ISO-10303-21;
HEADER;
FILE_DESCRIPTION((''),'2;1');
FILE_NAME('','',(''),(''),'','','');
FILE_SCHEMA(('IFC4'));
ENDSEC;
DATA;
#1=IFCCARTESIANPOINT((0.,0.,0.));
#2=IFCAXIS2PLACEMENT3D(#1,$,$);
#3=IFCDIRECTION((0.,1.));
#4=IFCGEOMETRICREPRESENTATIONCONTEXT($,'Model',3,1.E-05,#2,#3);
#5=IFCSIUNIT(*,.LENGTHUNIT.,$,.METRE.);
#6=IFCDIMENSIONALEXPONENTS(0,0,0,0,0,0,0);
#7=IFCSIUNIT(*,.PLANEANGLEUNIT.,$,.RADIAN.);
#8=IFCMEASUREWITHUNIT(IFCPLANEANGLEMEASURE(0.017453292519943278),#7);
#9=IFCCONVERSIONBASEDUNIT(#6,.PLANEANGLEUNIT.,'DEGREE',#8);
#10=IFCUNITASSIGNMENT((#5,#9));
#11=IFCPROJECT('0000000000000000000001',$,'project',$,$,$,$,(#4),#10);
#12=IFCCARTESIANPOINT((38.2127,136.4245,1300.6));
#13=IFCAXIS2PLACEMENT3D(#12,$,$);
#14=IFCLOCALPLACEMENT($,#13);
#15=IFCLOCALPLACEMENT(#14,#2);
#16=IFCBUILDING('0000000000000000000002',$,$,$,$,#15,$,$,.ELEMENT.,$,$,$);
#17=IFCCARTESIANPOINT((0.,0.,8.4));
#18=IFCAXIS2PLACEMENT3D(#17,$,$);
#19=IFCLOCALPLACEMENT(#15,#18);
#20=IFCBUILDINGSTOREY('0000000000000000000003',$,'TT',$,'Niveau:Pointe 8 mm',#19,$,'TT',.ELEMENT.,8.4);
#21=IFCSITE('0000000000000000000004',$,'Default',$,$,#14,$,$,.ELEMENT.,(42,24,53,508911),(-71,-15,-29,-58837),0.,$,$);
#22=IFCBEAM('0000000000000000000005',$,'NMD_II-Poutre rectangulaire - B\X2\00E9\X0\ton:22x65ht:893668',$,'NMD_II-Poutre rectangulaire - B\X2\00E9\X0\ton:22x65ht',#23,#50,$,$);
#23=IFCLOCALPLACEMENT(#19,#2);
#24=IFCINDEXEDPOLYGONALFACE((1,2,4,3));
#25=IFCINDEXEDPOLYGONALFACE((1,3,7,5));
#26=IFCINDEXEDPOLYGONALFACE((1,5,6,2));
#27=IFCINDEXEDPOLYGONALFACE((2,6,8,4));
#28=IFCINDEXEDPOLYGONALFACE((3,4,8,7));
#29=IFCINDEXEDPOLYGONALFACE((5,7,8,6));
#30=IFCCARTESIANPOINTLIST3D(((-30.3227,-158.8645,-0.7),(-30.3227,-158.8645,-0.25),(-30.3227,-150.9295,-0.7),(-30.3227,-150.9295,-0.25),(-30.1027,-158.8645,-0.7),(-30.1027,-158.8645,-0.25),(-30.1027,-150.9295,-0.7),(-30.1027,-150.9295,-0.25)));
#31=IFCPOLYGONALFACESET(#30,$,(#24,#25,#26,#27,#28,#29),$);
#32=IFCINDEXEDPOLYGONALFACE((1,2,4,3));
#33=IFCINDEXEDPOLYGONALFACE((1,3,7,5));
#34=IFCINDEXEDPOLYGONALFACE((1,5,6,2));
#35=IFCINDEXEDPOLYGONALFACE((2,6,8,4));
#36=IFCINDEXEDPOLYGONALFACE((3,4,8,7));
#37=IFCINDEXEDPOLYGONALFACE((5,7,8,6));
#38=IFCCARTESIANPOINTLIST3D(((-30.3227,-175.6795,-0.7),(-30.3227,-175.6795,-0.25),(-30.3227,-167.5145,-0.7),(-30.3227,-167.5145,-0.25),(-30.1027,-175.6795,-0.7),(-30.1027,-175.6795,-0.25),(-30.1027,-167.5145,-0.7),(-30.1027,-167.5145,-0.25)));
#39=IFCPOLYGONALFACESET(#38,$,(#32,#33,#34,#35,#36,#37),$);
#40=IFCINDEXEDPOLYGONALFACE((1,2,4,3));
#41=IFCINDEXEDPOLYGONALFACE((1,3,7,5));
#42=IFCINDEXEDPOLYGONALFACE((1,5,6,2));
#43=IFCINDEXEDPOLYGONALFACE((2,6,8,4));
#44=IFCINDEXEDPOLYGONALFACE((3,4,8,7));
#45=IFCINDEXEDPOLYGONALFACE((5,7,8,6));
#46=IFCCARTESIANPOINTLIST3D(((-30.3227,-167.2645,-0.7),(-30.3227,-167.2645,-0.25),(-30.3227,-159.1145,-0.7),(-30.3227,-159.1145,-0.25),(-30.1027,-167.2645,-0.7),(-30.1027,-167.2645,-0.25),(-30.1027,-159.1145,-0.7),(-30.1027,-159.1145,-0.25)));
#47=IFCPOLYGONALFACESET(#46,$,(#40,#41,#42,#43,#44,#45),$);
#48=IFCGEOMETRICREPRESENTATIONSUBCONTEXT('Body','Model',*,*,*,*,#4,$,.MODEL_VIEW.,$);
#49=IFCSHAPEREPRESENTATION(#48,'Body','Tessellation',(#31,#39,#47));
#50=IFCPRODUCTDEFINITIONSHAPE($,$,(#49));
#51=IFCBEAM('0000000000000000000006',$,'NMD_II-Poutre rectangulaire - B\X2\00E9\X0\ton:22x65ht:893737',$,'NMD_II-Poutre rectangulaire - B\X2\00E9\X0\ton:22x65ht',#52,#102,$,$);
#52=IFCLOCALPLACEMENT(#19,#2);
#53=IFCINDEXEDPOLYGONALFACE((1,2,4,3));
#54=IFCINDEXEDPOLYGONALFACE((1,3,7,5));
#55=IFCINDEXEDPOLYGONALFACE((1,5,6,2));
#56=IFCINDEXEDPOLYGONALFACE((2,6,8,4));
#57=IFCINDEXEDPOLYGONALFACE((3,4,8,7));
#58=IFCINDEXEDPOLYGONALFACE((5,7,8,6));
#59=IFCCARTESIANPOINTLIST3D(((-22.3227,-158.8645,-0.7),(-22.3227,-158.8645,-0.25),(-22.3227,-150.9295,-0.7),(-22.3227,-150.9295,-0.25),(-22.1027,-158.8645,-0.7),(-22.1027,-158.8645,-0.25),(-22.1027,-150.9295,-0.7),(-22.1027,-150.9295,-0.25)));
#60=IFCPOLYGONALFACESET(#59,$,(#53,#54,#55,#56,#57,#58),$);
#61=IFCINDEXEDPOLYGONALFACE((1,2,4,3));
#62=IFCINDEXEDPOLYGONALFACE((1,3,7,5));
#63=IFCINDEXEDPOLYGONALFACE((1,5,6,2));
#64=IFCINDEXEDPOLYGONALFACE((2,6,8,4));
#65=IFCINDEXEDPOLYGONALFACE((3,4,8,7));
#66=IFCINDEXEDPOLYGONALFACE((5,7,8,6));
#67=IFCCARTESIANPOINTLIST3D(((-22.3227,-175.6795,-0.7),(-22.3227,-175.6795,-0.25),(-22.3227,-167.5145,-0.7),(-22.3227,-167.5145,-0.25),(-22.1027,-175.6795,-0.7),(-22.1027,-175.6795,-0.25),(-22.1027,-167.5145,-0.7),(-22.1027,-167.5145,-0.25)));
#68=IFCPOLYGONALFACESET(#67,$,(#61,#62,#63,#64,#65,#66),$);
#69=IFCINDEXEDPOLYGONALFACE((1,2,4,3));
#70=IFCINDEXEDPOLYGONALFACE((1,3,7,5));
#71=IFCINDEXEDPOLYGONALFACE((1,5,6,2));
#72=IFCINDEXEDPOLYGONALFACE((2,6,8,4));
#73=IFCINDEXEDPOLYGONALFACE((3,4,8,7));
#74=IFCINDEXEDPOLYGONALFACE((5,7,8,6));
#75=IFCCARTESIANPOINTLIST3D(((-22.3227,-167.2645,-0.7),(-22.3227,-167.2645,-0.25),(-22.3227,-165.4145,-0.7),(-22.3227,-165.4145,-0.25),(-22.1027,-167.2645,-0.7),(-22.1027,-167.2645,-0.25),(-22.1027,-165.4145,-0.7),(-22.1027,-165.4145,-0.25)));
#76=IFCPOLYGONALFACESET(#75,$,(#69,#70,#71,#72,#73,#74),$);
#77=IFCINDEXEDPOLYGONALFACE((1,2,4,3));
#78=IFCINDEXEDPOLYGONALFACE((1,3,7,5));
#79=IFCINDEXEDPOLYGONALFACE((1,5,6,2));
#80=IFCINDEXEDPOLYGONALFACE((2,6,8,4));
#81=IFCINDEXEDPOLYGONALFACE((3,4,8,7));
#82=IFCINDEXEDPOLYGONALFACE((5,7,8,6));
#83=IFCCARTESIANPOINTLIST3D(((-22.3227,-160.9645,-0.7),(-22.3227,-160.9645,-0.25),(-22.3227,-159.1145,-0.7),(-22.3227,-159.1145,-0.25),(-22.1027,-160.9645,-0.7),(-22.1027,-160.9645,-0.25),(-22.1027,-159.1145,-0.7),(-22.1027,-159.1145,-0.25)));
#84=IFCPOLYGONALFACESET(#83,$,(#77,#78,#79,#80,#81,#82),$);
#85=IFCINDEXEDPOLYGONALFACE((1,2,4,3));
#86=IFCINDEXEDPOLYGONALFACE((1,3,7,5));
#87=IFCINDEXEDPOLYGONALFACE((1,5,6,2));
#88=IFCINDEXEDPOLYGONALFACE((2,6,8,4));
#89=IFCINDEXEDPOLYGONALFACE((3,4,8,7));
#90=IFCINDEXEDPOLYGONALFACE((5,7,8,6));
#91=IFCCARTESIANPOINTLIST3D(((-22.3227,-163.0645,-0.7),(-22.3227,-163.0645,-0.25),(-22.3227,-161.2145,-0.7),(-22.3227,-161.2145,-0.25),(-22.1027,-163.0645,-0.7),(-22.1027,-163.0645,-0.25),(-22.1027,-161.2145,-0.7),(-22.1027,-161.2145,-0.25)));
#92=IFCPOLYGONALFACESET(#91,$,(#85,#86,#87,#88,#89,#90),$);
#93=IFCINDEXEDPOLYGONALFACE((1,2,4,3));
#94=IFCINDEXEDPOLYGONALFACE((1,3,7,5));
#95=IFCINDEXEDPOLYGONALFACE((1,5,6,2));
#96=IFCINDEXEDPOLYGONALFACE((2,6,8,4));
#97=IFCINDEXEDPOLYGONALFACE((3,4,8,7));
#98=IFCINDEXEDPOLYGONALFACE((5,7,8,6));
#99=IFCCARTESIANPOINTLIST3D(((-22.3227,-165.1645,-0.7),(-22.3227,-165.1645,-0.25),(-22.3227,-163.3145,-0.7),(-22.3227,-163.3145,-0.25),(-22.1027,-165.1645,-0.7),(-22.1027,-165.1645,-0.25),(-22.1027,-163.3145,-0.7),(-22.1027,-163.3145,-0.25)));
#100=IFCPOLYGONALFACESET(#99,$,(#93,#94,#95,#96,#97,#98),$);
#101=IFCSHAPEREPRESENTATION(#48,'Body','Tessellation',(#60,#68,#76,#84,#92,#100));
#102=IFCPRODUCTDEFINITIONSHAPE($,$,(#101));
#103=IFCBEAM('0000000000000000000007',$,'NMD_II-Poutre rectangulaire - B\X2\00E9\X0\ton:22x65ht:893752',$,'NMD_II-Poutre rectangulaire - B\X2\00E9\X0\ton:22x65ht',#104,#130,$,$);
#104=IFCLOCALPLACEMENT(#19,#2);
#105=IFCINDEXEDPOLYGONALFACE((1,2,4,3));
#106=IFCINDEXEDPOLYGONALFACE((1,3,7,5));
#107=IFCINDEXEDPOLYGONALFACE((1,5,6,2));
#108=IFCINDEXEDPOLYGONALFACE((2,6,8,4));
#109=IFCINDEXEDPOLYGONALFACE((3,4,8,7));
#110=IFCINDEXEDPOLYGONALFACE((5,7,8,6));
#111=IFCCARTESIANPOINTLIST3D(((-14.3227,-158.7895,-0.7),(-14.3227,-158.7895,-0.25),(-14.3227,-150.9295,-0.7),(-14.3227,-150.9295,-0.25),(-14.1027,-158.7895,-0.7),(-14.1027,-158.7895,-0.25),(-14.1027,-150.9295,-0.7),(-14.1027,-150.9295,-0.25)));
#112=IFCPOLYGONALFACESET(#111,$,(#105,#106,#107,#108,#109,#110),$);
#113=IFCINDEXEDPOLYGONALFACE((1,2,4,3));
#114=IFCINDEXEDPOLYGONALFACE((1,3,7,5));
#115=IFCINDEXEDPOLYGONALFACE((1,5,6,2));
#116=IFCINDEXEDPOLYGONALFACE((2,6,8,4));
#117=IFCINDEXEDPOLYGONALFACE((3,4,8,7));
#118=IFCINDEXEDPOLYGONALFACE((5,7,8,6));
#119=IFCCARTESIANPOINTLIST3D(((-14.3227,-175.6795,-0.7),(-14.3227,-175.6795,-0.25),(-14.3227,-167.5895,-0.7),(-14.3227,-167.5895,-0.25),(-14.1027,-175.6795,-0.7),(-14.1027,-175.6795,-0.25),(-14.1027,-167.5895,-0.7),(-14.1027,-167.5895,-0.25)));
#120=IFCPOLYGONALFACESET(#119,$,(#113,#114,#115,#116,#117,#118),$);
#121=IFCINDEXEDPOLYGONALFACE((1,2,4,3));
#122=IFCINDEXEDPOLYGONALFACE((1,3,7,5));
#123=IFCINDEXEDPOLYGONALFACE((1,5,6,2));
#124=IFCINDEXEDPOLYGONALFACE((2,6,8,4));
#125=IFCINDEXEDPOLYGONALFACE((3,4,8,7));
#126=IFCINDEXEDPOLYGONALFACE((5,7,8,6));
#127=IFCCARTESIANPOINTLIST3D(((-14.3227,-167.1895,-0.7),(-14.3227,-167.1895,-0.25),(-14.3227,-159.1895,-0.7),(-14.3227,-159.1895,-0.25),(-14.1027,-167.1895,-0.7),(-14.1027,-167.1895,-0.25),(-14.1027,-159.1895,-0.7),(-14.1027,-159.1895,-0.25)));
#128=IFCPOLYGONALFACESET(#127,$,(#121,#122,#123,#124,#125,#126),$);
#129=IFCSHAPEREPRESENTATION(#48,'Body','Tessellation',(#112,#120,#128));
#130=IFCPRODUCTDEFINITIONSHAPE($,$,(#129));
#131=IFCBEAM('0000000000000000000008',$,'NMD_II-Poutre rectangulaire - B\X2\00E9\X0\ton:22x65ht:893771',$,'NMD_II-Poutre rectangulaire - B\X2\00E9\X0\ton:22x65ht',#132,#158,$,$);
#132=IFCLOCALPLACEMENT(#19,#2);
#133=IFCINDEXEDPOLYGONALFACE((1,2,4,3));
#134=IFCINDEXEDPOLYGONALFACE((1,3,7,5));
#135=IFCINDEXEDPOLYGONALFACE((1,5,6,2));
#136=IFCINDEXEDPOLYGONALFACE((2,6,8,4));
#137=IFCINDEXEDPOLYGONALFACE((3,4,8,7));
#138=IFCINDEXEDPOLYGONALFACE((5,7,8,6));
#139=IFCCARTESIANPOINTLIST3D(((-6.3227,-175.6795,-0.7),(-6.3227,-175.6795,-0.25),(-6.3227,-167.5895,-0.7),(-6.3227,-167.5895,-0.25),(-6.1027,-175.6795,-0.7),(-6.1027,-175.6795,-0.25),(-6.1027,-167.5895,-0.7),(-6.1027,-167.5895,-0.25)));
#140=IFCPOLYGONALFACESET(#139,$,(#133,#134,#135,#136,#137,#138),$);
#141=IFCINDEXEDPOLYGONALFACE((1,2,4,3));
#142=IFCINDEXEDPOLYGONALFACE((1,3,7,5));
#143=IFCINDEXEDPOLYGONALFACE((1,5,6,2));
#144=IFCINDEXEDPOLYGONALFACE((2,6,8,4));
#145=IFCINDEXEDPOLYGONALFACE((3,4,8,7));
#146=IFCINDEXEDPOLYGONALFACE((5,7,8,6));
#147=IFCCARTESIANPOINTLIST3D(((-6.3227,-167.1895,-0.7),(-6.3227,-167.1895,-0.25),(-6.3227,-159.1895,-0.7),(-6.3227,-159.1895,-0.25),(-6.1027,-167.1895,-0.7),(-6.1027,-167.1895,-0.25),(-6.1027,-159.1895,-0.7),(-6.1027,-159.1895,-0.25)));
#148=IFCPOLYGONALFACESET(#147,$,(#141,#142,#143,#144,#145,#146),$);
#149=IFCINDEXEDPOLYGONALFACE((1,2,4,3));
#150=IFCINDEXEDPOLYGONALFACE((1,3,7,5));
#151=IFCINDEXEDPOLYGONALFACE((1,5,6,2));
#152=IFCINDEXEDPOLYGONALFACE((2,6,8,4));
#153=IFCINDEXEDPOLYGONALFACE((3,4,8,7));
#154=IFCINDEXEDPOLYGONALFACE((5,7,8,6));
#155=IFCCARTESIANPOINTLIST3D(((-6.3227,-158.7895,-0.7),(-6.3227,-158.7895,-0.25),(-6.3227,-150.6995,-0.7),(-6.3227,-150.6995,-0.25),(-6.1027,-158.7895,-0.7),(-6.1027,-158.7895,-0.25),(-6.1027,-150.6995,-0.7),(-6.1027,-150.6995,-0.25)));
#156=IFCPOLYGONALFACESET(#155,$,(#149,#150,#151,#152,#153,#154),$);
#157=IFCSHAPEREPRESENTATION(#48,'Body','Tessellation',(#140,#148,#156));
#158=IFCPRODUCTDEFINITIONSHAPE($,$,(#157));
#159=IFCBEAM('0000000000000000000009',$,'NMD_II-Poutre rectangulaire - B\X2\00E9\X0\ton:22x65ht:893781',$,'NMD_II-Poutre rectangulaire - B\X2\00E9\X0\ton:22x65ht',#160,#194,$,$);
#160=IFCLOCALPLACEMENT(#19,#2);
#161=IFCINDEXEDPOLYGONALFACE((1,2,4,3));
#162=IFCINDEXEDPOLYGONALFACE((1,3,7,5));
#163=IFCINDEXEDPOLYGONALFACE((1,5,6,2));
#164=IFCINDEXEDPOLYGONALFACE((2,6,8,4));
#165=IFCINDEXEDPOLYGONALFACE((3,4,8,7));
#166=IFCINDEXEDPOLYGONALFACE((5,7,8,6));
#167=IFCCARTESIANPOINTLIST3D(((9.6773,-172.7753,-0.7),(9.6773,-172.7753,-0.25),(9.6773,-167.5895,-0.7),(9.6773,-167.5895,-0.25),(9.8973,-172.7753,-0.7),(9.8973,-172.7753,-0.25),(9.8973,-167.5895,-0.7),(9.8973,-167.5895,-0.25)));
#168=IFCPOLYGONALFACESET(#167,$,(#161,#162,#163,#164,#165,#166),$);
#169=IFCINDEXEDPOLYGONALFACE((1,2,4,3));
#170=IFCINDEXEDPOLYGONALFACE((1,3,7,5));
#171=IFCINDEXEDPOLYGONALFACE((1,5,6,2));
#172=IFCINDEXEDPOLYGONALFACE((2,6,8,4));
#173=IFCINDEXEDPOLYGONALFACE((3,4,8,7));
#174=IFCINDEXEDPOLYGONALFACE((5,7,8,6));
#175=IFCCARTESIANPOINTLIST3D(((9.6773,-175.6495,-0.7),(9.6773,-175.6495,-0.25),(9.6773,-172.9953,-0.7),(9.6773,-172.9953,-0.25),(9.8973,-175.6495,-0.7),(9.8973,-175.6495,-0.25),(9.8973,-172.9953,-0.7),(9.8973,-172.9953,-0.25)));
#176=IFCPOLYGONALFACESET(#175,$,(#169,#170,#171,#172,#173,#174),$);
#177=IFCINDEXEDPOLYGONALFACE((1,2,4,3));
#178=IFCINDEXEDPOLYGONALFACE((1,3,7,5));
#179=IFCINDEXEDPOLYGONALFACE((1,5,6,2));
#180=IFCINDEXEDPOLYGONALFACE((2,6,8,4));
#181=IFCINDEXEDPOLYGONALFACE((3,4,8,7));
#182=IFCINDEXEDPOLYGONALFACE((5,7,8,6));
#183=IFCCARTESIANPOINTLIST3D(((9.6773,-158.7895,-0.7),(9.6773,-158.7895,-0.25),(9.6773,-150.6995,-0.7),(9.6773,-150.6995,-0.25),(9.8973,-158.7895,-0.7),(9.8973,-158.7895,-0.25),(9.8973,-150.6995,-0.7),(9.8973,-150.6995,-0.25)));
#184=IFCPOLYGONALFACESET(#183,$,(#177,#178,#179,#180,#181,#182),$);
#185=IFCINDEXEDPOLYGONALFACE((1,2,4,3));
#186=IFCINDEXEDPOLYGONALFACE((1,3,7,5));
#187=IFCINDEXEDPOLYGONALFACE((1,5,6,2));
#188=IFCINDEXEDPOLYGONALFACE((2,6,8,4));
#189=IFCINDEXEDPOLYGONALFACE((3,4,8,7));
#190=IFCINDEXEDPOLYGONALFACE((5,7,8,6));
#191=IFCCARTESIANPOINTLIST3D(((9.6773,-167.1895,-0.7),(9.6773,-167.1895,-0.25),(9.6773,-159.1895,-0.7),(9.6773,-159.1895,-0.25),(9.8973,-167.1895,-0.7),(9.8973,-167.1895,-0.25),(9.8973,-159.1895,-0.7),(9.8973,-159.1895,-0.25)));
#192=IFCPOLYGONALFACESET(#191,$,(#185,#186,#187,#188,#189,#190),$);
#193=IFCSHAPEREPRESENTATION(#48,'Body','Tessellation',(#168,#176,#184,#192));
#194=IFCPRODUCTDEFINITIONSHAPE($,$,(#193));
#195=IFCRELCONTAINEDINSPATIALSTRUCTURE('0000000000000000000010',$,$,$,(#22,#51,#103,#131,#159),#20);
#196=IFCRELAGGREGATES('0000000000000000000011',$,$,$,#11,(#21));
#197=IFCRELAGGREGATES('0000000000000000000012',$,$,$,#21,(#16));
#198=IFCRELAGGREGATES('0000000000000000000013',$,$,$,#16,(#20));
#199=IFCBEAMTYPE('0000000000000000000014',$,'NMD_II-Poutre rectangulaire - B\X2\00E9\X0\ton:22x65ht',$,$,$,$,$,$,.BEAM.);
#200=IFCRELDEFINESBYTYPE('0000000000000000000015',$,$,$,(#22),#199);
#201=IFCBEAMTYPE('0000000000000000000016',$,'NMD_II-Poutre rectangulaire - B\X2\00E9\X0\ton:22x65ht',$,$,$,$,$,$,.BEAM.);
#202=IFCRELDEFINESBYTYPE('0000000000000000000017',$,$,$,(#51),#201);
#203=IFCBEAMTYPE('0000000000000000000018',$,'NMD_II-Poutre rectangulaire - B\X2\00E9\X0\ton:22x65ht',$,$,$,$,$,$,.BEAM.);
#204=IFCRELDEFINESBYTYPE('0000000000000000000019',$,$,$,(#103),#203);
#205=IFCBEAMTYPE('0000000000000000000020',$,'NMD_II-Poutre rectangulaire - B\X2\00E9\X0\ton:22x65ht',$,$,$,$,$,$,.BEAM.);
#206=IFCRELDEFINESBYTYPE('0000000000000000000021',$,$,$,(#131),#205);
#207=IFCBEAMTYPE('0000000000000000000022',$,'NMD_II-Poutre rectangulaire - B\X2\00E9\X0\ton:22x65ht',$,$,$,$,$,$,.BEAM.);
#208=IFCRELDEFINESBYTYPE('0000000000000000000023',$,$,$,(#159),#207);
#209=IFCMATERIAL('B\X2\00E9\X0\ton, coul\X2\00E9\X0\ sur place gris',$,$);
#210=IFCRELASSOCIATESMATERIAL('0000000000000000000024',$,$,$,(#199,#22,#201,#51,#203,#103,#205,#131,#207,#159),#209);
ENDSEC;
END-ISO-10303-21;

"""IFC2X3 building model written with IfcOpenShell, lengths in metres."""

from ifc_helpers import new_model, entity, si_unit, converted_unit, direction, frame, frame_2d, origin, place, context, subcontext, project, spatial, rectangle, extrude, source, transform, mapped, material, type_object, type_shapes, element, save


model = new_model("IFC2X3")

# Units and contexts
model_context = context("Model", 3, precision=1e-05, world=origin(), true_north=direction((0.0, 1.0)))
body_context = subcontext(model_context, "Body", "Model", "MODEL_VIEW")
ifc_project = project(units=[si_unit("LENGTHUNIT", "METRE"), converted_unit("PLANEANGLEUNIT", "DEGREE", entity("IfcPlaneAngleMeasure", 0.017453292519943278), si_unit("PLANEANGLEUNIT", "RADIAN"), dimensions=[0, 0, 0, 0, 0, 0, 0])], contexts=[model_context])

# Site, building, storey
site_placement = place(None, frame((38.2127, 136.4245, 1300.6)))
site = spatial("IfcSite", under=ifc_project, at=site_placement, Name="Default", CompositionType="ELEMENT", RefLatitude=(42, 24, 53, 508911), RefLongitude=(-71, -15, -29, -58837), RefElevation=0.0)
building_placement = place(site_placement, origin())
building = spatial("IfcBuilding", under=site, at=building_placement, CompositionType="ELEMENT")
storey_placement = place(building_placement, frame((0.0, 0.0, 8.4)))
storey = spatial("IfcBuildingStorey", under=building, at=storey_placement, Name="TT", ObjectType="Niveau:Pointe 8 mm", LongName="TT", CompositionType="ELEMENT", Elevation=8.4)

# Beams
ifc_material_1 = material(Name="Béton, coulé sur place gris")
beam_type_1 = type_object("IfcBeamType", Name="NMD_II-Poutre rectangulaire - Béton:22x65ht", PredefinedType="BEAM", material=ifc_material_1)
shared_shape_1 = source(origin(), body_context, "Body", "SweptSolid", [
    extrude(rectangle(XDim=0.45, YDim=0.22, at=frame_2d((0.0, 0.0), x_axis=(0.0, 1.0))), frame((-30.2127, -158.8645, 7.925), z_axis=(0.0, 1.0, 0.0), x_axis=(-1.0, 0.0, 0.0)), (0.0, 0.0, 1.0), 7.935),
    extrude(rectangle(XDim=0.45, YDim=0.22, at=frame_2d((0.0, 0.0), x_axis=(0.0, 1.0))), frame((-30.2127, -175.6795, 7.925), z_axis=(0.0, 1.0, 0.0), x_axis=(-1.0, 0.0, 0.0)), (0.0, 0.0, 1.0), 8.165),
    extrude(rectangle(XDim=0.45, YDim=0.22, at=frame_2d((0.0, 0.0), x_axis=(0.0, 1.0))), frame((-30.2127, -167.2645, 7.925), z_axis=(0.0, 1.0, 0.0), x_axis=(-1.0, 0.0, 0.0)), (0.0, 0.0, 1.0), 8.15),
])
type_shapes(beam_type_1, [shared_shape_1])
beam_1_placement = place(storey_placement, frame((0.0, 0.0, -8.4)))
element("IfcBeam", 1, at=beam_1_placement, inside=storey, type_object=beam_type_1, material=ifc_material_1, Name="NMD_II-Poutre rectangulaire - Béton:22x65ht:893668", ObjectType="NMD_II-Poutre rectangulaire - Béton:22x65ht", context=body_context, shape_type="MappedRepresentation", body=[
    mapped(shared_shape_1, transform((0.0, 0.0, 0.0), scale=1.0)),
])
beam_type_2 = type_object("IfcBeamType", Name="NMD_II-Poutre rectangulaire - Béton:22x65ht", PredefinedType="BEAM", material=ifc_material_1)
shared_shape_2 = source(origin(), body_context, "Body", "SweptSolid", [
    extrude(rectangle(XDim=0.45, YDim=0.22, at=frame_2d((0.0, 0.0), x_axis=(0.0, 1.0))), frame((-22.2127, -158.8645, 7.925), z_axis=(0.0, 1.0, 0.0), x_axis=(-1.0, 0.0, 0.0)), (0.0, 0.0, 1.0), 7.935),
    extrude(rectangle(XDim=0.45, YDim=0.22, at=frame_2d((0.0, 0.0), x_axis=(0.0, 1.0))), frame((-22.2127, -175.6795, 7.925), z_axis=(0.0, 1.0, 0.0), x_axis=(-1.0, 0.0, 0.0)), (0.0, 0.0, 1.0), 8.165),
    extrude(rectangle(XDim=0.45, YDim=0.22, at=frame_2d((0.0, 0.0), x_axis=(0.0, 1.0))), frame((-22.2127, -167.2645, 7.925), z_axis=(0.0, 1.0, 0.0), x_axis=(-1.0, 0.0, 0.0)), (0.0, 0.0, 1.0), 1.85),
    extrude(rectangle(XDim=0.45, YDim=0.22, at=frame_2d((0.0, 0.0), x_axis=(0.0, 1.0))), frame((-22.2127, -160.9645, 7.925), z_axis=(0.0, 1.0, 0.0), x_axis=(-1.0, 0.0, 0.0)), (0.0, 0.0, 1.0), 1.85),
    extrude(rectangle(XDim=0.45, YDim=0.22, at=frame_2d((0.0, 0.0), x_axis=(0.0, 1.0))), frame((-22.2127, -163.0645, 7.925), z_axis=(0.0, 1.0, 0.0), x_axis=(-1.0, 0.0, 0.0)), (0.0, 0.0, 1.0), 1.85),
    extrude(rectangle(XDim=0.45, YDim=0.22, at=frame_2d((0.0, 0.0), x_axis=(0.0, 1.0))), frame((-22.2127, -165.1645, 7.925), z_axis=(0.0, 1.0, 0.0), x_axis=(-1.0, 0.0, 0.0)), (0.0, 0.0, 1.0), 1.85),
])
type_shapes(beam_type_2, [shared_shape_2])
beam_2_placement = place(storey_placement, frame((0.0, 0.0, -8.4)))
element("IfcBeam", 2, at=beam_2_placement, inside=storey, type_object=beam_type_2, material=ifc_material_1, Name="NMD_II-Poutre rectangulaire - Béton:22x65ht:893737", ObjectType="NMD_II-Poutre rectangulaire - Béton:22x65ht", context=body_context, shape_type="MappedRepresentation", body=[
    mapped(shared_shape_2, transform((0.0, 0.0, 0.0), scale=1.0)),
])
beam_type_3 = type_object("IfcBeamType", Name="NMD_II-Poutre rectangulaire - Béton:22x65ht", PredefinedType="BEAM", material=ifc_material_1)
shared_shape_3 = source(origin(), body_context, "Body", "SweptSolid", [
    extrude(rectangle(XDim=0.45, YDim=0.22, at=frame_2d((0.0, 0.0), x_axis=(0.0, 1.0))), frame((-14.2127, -158.7895, 7.925), z_axis=(0.0, 1.0, 0.0), x_axis=(-1.0, 0.0, 0.0)), (0.0, 0.0, 1.0), 7.86),
    extrude(rectangle(XDim=0.45, YDim=0.22, at=frame_2d((0.0, 0.0), x_axis=(0.0, 1.0))), frame((-14.2127, -175.6795, 7.925), z_axis=(0.0, 1.0, 0.0), x_axis=(-1.0, 0.0, 0.0)), (0.0, 0.0, 1.0), 8.09),
    extrude(rectangle(XDim=0.45, YDim=0.22, at=frame_2d((0.0, 0.0), x_axis=(0.0, 1.0))), frame((-14.2127, -167.1895, 7.925), z_axis=(0.0, 1.0, 0.0), x_axis=(-1.0, 0.0, 0.0)), (0.0, 0.0, 1.0), 8.0),
])
type_shapes(beam_type_3, [shared_shape_3])
beam_3_placement = place(storey_placement, frame((0.0, 0.0, -8.4)))
element("IfcBeam", 3, at=beam_3_placement, inside=storey, type_object=beam_type_3, material=ifc_material_1, Name="NMD_II-Poutre rectangulaire - Béton:22x65ht:893752", ObjectType="NMD_II-Poutre rectangulaire - Béton:22x65ht", context=body_context, shape_type="MappedRepresentation", body=[
    mapped(shared_shape_3, transform((0.0, 0.0, 0.0), scale=1.0)),
])
beam_type_4 = type_object("IfcBeamType", Name="NMD_II-Poutre rectangulaire - Béton:22x65ht", PredefinedType="BEAM", material=ifc_material_1)
shared_shape_4 = source(origin(), body_context, "Body", "SweptSolid", [
    extrude(rectangle(XDim=0.45, YDim=0.22, at=frame_2d((0.0, 0.0), x_axis=(0.0, 1.0))), frame((-6.2127, -175.6795, 7.925), z_axis=(0.0, 1.0, 0.0), x_axis=(-1.0, 0.0, 0.0)), (0.0, 0.0, 1.0), 8.09),
    extrude(rectangle(XDim=0.45, YDim=0.22, at=frame_2d((0.0, 0.0), x_axis=(0.0, 1.0))), frame((-6.2127, -167.1895, 7.925), z_axis=(0.0, 1.0, 0.0), x_axis=(-1.0, 0.0, 0.0)), (0.0, 0.0, 1.0), 8.0),
    extrude(rectangle(XDim=0.45, YDim=0.22, at=frame_2d((0.0, 0.0), x_axis=(0.0, 1.0))), frame((-6.2127, -158.7895, 7.925), z_axis=(0.0, 1.0, 0.0), x_axis=(-1.0, 0.0, 0.0)), (0.0, 0.0, 1.0), 8.09),
])
type_shapes(beam_type_4, [shared_shape_4])
beam_4_placement = place(storey_placement, frame((0.0, 0.0, -8.4)))
element("IfcBeam", 4, at=beam_4_placement, inside=storey, type_object=beam_type_4, material=ifc_material_1, Name="NMD_II-Poutre rectangulaire - Béton:22x65ht:893771", ObjectType="NMD_II-Poutre rectangulaire - Béton:22x65ht", context=body_context, shape_type="MappedRepresentation", body=[
    mapped(shared_shape_4, transform((0.0, 0.0, 0.0), scale=1.0)),
])
beam_type_5 = type_object("IfcBeamType", Name="NMD_II-Poutre rectangulaire - Béton:22x65ht", PredefinedType="BEAM", material=ifc_material_1)
shared_shape_5 = source(origin(), body_context, "Body", "SweptSolid", [
    extrude(rectangle(XDim=0.45, YDim=0.22, at=frame_2d((0.0, 0.0), x_axis=(0.0, 1.0))), frame((9.7873, -172.7753, 7.925), z_axis=(0.0, 1.0, 0.0), x_axis=(-1.0, 0.0, 0.0)), (0.0, 0.0, 1.0), 5.1859),
    extrude(rectangle(XDim=0.45, YDim=0.22, at=frame_2d((0.0, 0.0), x_axis=(0.0, 1.0))), frame((9.7873, -175.6495, 7.925), z_axis=(0.0, 1.0, 0.0), x_axis=(-1.0, 0.0, 0.0)), (0.0, 0.0, 1.0), 2.6541),
    extrude(rectangle(XDim=0.45, YDim=0.22, at=frame_2d((0.0, 0.0), x_axis=(0.0, 1.0))), frame((9.7873, -158.7895, 7.925), z_axis=(0.0, 1.0, 0.0), x_axis=(-1.0, 0.0, 0.0)), (0.0, 0.0, 1.0), 8.09),
    extrude(rectangle(XDim=0.45, YDim=0.22, at=frame_2d((0.0, 0.0), x_axis=(0.0, 1.0))), frame((9.7873, -167.1895, 7.925), z_axis=(0.0, 1.0, 0.0), x_axis=(-1.0, 0.0, 0.0)), (0.0, 0.0, 1.0), 8.0),
])
type_shapes(beam_type_5, [shared_shape_5])
beam_5_placement = place(storey_placement, frame((0.0, 0.0, -8.4)))
element("IfcBeam", 5, at=beam_5_placement, inside=storey, type_object=beam_type_5, material=ifc_material_1, Name="NMD_II-Poutre rectangulaire - Béton:22x65ht:893781", ObjectType="NMD_II-Poutre rectangulaire - Béton:22x65ht", context=body_context, shape_type="MappedRepresentation", body=[
    mapped(shared_shape_5, transform((0.0, 0.0, 0.0), scale=1.0)),
])

save(model, "model.ifc")
